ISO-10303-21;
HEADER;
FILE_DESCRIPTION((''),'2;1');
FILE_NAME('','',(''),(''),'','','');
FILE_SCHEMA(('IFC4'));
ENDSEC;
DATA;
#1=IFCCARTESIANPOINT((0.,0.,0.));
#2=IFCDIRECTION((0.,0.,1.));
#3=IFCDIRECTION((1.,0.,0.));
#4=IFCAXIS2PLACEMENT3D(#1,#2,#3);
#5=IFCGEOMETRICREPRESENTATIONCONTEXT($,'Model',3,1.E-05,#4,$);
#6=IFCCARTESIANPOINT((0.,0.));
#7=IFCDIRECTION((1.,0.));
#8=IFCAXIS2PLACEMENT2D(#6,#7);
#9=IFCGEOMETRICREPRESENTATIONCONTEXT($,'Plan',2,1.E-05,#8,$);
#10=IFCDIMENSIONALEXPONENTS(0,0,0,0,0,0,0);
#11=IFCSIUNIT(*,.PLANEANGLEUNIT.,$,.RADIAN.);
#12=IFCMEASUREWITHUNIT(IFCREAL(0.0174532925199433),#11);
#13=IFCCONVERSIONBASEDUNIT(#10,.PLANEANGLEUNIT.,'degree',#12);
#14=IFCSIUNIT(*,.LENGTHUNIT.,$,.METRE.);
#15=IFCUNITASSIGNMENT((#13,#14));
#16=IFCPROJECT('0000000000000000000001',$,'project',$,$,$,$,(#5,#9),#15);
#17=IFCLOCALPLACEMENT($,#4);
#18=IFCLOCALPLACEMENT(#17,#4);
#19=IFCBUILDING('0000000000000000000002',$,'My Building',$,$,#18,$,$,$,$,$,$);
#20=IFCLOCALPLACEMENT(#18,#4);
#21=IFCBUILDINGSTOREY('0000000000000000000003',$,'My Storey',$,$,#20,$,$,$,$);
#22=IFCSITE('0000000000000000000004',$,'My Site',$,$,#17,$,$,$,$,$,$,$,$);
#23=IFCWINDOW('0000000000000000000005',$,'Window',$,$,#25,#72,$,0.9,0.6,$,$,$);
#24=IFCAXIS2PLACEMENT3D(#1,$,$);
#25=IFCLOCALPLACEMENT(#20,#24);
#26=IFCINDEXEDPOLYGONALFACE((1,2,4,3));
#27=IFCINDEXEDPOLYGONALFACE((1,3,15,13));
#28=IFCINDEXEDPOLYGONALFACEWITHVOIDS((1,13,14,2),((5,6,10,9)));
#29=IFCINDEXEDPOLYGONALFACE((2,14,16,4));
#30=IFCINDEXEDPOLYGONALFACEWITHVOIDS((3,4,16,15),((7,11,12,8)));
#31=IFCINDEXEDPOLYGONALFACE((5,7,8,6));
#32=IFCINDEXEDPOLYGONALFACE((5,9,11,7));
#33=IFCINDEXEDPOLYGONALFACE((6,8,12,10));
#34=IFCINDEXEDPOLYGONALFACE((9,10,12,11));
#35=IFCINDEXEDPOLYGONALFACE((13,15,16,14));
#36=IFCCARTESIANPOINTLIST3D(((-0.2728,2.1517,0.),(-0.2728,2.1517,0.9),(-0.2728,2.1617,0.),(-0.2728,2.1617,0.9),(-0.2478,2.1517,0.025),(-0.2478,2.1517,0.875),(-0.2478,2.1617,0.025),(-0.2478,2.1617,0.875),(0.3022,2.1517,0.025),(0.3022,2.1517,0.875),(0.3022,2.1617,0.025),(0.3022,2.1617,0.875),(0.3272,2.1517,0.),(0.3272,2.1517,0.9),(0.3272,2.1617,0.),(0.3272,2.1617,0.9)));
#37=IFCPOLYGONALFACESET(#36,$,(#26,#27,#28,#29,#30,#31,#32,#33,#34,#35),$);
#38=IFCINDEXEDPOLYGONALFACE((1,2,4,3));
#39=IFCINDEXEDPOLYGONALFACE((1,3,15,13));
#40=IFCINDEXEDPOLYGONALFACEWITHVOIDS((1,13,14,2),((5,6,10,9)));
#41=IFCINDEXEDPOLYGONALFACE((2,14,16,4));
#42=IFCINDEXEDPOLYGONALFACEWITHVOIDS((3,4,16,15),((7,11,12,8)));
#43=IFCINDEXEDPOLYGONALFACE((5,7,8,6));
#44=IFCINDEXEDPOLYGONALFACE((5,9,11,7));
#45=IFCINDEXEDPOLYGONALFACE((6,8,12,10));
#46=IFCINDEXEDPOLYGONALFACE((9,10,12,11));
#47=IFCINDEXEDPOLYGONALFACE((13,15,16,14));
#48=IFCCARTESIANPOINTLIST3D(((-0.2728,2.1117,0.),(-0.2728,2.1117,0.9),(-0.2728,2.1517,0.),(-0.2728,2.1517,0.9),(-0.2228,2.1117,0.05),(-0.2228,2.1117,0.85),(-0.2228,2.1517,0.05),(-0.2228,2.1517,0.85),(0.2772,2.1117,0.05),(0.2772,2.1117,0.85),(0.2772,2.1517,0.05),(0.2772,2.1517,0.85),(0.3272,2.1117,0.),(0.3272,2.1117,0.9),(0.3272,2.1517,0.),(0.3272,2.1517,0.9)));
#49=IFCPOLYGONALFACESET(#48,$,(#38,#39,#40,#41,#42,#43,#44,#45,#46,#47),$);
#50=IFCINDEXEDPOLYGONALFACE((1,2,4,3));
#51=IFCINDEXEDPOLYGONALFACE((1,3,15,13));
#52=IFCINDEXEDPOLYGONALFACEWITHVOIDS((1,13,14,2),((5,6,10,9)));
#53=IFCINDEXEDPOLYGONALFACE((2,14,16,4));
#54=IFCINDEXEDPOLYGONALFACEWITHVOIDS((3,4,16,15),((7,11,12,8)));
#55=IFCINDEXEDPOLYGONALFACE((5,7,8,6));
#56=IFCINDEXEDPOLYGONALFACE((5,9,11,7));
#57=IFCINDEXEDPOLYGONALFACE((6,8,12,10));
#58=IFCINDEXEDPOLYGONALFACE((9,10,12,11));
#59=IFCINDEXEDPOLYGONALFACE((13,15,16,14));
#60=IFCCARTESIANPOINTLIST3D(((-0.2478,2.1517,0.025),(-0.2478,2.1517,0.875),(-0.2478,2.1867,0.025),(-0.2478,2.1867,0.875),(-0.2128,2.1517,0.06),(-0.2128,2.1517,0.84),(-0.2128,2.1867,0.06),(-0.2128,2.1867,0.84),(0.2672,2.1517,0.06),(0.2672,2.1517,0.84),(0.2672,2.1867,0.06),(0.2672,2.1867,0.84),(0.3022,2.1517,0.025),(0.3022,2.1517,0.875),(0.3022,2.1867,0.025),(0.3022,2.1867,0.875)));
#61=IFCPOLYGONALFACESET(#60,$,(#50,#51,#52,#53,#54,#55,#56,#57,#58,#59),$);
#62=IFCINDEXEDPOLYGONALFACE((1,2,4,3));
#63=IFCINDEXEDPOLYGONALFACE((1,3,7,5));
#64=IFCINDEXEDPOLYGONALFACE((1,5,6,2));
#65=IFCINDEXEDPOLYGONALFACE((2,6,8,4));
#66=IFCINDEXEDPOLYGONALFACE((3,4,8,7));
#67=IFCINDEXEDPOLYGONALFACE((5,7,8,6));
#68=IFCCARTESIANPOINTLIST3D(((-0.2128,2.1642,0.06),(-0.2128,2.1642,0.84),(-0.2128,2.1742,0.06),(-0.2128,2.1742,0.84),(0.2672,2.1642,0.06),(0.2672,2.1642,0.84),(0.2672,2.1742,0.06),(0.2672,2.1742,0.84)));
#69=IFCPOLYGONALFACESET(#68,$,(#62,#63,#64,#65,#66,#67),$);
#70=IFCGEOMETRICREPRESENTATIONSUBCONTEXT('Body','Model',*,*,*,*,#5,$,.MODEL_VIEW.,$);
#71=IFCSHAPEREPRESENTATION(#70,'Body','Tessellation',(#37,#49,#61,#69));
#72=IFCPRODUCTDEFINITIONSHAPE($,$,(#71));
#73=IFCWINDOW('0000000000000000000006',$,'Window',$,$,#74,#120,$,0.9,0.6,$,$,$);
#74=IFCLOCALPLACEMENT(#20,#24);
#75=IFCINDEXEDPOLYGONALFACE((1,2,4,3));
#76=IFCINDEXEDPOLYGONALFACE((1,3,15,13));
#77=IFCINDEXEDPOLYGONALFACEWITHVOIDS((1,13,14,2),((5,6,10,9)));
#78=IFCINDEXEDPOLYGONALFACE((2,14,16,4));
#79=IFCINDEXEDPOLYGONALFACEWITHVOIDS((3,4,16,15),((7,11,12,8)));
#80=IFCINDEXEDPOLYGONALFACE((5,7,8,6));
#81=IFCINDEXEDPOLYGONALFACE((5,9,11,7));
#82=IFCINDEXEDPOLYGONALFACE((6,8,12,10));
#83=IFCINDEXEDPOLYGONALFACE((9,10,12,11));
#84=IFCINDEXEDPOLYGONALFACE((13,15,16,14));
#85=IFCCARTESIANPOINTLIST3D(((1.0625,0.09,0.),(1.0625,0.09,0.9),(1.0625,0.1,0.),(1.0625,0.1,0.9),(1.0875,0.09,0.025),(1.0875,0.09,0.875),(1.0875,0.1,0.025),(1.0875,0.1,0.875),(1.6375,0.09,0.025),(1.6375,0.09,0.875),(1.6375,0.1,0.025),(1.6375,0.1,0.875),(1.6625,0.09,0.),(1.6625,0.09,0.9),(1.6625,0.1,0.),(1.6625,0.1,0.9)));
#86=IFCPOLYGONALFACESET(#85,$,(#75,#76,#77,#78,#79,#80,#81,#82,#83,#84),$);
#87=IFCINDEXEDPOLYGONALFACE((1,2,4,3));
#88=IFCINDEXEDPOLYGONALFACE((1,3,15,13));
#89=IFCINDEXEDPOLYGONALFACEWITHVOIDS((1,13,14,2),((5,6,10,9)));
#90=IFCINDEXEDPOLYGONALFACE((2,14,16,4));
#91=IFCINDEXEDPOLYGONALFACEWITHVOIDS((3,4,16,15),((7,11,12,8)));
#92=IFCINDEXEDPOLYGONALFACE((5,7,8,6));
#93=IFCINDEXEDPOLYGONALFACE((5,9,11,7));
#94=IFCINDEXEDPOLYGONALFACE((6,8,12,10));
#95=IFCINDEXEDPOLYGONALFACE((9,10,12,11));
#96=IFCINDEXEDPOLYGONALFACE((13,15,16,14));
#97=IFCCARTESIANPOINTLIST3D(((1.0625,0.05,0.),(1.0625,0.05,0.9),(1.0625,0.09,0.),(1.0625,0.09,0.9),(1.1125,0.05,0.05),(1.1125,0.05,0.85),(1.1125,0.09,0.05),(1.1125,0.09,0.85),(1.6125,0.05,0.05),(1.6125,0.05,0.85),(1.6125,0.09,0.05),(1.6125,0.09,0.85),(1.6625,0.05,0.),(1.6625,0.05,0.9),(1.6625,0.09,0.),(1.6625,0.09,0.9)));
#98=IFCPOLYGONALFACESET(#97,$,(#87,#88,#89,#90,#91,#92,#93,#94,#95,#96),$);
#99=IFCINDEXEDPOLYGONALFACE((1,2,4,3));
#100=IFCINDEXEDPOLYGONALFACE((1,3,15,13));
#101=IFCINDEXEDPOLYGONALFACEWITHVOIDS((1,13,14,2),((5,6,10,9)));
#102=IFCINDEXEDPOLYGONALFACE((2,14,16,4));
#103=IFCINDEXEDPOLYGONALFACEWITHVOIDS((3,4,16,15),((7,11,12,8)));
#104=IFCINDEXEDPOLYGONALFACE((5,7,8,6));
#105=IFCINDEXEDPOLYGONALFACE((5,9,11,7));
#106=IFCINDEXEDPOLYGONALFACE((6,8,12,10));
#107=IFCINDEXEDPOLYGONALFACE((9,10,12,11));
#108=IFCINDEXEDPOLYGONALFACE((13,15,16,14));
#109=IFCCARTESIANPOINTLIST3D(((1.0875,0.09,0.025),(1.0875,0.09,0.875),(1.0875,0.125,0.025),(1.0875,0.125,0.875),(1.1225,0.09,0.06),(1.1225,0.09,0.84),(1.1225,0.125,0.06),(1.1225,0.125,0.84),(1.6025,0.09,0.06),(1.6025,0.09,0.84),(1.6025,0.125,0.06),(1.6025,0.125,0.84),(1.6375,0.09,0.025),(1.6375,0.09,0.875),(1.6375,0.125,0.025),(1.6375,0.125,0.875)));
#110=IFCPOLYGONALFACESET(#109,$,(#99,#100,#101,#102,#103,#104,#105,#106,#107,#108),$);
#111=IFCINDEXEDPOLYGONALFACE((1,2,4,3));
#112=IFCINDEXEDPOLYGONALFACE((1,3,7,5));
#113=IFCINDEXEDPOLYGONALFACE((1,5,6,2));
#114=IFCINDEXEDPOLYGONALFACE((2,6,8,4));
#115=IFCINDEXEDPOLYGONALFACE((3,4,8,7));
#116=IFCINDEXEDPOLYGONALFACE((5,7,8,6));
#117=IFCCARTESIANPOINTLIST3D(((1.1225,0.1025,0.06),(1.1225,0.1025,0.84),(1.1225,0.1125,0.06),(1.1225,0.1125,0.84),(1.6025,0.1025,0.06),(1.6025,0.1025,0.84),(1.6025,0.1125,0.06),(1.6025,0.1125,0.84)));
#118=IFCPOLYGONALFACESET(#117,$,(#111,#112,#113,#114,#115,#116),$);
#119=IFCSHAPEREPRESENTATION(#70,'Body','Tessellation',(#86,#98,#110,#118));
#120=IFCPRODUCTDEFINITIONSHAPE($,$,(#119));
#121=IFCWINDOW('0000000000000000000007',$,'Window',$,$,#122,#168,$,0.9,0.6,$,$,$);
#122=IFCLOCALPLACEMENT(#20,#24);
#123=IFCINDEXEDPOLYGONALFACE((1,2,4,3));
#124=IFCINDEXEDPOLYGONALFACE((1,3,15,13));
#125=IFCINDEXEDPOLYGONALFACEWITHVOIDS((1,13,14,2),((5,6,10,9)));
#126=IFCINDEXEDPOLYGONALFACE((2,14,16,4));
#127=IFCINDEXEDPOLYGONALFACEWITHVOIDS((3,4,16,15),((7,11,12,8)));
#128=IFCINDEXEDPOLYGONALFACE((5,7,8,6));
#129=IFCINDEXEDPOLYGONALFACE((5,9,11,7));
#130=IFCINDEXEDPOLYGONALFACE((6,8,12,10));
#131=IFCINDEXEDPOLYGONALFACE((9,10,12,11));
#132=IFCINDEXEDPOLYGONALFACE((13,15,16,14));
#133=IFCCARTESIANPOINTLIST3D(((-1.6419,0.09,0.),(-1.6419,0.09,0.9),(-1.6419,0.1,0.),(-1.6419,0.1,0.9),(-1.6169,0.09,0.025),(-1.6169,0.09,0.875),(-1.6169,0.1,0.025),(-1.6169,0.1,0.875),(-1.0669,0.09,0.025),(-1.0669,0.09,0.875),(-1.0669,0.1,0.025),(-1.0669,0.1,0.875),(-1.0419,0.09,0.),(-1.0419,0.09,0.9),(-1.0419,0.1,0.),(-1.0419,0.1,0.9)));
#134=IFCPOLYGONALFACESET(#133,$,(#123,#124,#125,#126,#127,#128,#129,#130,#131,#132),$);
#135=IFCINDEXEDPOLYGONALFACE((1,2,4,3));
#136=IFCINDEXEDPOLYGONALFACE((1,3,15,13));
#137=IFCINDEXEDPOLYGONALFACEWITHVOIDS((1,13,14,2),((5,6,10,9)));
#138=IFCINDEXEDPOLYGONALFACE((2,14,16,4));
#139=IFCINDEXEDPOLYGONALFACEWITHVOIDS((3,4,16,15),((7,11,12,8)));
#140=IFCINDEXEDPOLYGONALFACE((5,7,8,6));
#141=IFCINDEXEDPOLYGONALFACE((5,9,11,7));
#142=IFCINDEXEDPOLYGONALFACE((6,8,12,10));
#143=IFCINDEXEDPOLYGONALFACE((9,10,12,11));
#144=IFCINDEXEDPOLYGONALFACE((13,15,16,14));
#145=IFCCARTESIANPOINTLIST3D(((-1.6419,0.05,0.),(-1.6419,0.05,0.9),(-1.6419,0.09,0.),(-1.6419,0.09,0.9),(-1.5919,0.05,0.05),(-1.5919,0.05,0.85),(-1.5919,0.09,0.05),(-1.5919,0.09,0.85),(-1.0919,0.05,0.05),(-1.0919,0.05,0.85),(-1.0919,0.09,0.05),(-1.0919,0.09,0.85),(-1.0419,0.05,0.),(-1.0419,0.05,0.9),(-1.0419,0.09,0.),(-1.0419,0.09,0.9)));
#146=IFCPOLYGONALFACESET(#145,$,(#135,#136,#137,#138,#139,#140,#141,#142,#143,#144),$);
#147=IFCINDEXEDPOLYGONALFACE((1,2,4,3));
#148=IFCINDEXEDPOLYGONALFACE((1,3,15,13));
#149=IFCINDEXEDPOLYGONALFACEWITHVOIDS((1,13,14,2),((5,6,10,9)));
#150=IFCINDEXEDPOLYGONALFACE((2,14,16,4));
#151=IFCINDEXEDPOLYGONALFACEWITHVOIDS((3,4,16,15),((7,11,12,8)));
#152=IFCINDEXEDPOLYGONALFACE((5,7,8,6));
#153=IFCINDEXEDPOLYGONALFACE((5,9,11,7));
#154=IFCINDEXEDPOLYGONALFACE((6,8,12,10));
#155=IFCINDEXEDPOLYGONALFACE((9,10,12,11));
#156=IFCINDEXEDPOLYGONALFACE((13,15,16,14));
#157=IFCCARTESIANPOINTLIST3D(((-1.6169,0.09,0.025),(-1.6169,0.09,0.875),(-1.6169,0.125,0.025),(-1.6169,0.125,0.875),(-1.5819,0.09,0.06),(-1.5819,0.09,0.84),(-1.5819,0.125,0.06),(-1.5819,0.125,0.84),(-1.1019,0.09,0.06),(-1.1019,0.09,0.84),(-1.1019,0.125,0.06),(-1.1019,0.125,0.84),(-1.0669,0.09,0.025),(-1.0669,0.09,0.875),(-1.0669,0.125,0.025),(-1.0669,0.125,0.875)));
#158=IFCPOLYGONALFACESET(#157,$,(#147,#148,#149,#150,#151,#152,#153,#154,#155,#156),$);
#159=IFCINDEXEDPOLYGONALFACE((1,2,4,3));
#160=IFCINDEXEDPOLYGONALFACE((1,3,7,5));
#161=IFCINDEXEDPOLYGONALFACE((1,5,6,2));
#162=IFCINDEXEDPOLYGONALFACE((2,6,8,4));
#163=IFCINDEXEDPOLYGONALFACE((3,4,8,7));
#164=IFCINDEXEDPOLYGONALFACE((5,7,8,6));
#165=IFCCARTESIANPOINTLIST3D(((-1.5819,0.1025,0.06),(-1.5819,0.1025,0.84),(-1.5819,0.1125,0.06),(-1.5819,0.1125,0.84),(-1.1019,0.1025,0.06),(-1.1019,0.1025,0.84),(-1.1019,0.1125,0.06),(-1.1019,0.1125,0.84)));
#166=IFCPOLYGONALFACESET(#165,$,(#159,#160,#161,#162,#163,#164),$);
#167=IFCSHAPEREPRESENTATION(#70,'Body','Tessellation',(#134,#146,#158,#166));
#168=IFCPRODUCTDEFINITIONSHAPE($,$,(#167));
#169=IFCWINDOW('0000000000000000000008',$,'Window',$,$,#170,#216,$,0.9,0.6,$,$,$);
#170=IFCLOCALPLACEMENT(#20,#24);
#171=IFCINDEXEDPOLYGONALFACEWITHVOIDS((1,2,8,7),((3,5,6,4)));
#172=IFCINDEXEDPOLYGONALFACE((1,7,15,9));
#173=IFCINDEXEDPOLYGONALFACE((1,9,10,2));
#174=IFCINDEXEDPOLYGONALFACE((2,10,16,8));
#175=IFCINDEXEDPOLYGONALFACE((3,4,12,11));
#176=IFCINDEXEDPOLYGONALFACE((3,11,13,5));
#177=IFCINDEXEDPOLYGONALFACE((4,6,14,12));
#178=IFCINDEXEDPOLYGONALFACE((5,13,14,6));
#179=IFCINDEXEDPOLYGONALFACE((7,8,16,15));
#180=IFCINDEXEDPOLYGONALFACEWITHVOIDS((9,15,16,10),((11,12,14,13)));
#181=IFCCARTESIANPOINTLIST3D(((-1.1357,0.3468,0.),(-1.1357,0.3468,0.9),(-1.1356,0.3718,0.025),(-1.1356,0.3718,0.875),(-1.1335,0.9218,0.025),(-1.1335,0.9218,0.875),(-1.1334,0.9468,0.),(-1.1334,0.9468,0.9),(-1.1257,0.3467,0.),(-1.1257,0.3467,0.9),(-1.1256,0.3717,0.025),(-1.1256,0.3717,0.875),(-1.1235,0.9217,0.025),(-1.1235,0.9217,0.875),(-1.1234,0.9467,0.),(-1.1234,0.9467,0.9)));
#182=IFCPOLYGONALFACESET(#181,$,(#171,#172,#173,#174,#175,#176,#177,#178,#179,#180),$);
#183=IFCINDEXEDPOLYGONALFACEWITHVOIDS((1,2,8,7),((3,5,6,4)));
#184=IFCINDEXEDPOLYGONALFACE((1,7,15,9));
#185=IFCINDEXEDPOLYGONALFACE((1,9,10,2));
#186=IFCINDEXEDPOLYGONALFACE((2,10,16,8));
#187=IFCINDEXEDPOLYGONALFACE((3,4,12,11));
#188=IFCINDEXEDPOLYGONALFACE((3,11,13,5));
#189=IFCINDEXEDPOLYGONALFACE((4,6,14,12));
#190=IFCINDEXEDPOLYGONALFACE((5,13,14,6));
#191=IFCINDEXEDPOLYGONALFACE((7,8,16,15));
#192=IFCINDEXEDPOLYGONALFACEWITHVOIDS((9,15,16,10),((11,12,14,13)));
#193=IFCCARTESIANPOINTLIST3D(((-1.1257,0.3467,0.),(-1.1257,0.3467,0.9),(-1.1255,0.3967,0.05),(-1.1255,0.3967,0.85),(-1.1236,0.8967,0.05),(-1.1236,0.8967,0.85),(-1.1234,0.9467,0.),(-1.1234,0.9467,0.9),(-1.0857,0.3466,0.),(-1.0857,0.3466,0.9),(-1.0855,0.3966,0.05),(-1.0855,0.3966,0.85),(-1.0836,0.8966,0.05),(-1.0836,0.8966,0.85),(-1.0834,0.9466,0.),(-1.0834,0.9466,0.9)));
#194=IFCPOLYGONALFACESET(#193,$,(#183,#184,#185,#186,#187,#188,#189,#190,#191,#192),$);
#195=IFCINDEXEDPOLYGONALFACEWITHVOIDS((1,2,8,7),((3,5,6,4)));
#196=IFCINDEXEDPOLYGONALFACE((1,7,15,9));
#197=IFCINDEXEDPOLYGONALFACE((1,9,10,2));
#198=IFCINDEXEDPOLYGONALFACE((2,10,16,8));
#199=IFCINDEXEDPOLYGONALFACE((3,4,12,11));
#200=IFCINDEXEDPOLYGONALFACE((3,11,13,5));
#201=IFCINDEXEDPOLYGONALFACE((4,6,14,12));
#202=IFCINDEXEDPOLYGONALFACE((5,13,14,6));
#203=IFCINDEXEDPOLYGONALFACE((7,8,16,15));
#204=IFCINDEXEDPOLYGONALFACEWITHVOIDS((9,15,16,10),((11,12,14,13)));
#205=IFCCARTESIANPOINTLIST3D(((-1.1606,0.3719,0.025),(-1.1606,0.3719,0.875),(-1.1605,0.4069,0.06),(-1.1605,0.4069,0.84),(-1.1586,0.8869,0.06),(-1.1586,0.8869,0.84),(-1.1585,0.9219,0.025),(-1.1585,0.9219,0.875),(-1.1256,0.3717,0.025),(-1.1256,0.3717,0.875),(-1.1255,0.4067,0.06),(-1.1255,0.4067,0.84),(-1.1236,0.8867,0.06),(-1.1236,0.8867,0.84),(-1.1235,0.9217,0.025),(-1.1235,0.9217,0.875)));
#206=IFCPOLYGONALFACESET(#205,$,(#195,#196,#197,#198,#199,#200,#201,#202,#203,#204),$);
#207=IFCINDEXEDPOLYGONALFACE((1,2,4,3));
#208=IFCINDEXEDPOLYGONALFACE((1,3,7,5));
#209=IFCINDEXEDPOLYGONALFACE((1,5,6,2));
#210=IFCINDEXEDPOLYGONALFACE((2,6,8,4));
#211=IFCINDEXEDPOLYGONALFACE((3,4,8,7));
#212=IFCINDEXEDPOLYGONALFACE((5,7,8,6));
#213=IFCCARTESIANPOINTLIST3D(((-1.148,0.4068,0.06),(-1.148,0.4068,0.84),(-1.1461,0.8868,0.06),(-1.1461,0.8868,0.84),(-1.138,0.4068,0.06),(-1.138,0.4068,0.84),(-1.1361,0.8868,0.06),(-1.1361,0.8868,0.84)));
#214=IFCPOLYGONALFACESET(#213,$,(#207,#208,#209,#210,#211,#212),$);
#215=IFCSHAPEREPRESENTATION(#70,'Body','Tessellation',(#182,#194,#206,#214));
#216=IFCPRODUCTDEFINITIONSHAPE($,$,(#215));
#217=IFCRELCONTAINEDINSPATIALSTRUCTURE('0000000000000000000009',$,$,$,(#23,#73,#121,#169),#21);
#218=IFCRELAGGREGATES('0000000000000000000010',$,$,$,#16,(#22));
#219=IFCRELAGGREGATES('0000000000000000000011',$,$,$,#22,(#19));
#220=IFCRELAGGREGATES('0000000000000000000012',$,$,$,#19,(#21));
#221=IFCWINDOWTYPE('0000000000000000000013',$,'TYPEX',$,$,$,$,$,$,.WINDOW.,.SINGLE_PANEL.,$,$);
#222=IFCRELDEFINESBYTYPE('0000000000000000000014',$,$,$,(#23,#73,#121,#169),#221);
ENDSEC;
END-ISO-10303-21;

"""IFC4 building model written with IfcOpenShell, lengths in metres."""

from ifc_helpers import new_model, entity, si_unit, converted_unit, frame, origin_with_axes, origin_2d_with_axis, place, context, subcontext, project, spatial, line, indexed_curve, outline, extrude, shape, source, transform, mapped, type_object, type_shapes, element, save


model = new_model("IFC4")

# Units and contexts
model_context = context("Model", 3, precision=1e-05, world=origin_with_axes())
plan_context = context("Plan", 2, precision=1e-05, world=origin_2d_with_axis())
body_context_1 = subcontext(model_context, "Body", "Model", "MODEL_VIEW")
body_context_2 = subcontext(plan_context, "Body", "Plan", "PLAN_VIEW")
ifc_project = project(units=[converted_unit("PLANEANGLEUNIT", "degree", entity("IfcReal", 0.0174532925199433), si_unit("PLANEANGLEUNIT", "RADIAN"), dimensions=[0, 0, 0, 0, 0, 0, 0]), si_unit("LENGTHUNIT", "METRE")], contexts=[model_context, plan_context])

# Site, building, storey
site_placement = place(None, origin_with_axes())
site = spatial("IfcSite", under=ifc_project, at=site_placement, Name="My Site")
building_placement = place(site_placement, origin_with_axes())
building = spatial("IfcBuilding", under=site, at=building_placement, Name="My Building")
storey_placement = place(building_placement, origin_with_axes())
storey = spatial("IfcBuildingStorey", under=building, at=storey_placement, Name="My Storey")

# Windows
window_type = type_object("IfcWindowType", Name="TYPEX", PartitioningType="SINGLE_PANEL", PredefinedType="WINDOW")
shared_shape_1 = source(origin_with_axes(), body_context_1, "Body", "SweptSolid", [
    extrude(outline(indexed_curve([(0.0, 0.0), (0.6, 0.0), (0.6, 0.9), (0.0, 0.9)], segments=[line(1, 2, 3, 4, 1)]), holes=[indexed_curve([(0.025, 0.025), (0.575, 0.025), (0.575, 0.875), (0.025, 0.875)], segments=[line(1, 2, 3, 4, 1)])]), frame((0.0, 0.09, 0.0), z_axis=(0.0, -1.0, 0.0), x_axis=(1.0, 0.0, 0.0)), (0.0, 0.0, -1.0), 0.01),
    extrude(outline(indexed_curve([(0.0, 0.0), (0.6, 0.0), (0.6, 0.9), (0.0, 0.9)], segments=[line(1, 2, 3, 4, 1)]), holes=[indexed_curve([(0.05, 0.05), (0.55, 0.05), (0.55, 0.85), (0.05, 0.85)], segments=[line(1, 2, 3, 4, 1)])]), frame((0.0, 0.05, 0.0), z_axis=(0.0, -1.0, 0.0), x_axis=(1.0, 0.0, 0.0)), (0.0, 0.0, -1.0), 0.04),
    extrude(outline(indexed_curve([(0.0, 0.0), (0.55, 0.0), (0.55, 0.85), (0.0, 0.85)], segments=[line(1, 2, 3, 4, 1)]), holes=[indexed_curve([(0.035, 0.035), (0.515, 0.035), (0.515, 0.815), (0.035, 0.815)], segments=[line(1, 2, 3, 4, 1)])]), frame((0.025, 0.09, 0.025), z_axis=(0.0, -1.0, 0.0), x_axis=(1.0, 0.0, 0.0)), (0.0, 0.0, -1.0), 0.035),
    extrude(outline(indexed_curve([(0.035, 0.035), (0.515, 0.035), (0.515, 0.815), (0.035, 0.815)], segments=[line(1, 2, 3, 4, 1)])), frame((0.025, 0.1025, 0.025), z_axis=(0.0, -1.0, 0.0), x_axis=(1.0, 0.0, 0.0)), (0.0, 0.0, -1.0), 0.01),
])
shared_shape_2 = source(origin_with_axes(), body_context_2, "Body", "Curve2D", [
    entity("IfcIndexedPolyCurve", entity("IfcCartesianPointList2D", [[0.05, 0.05], [0.55, 0.05]])),
    entity("IfcIndexedPolyCurve", entity("IfcCartesianPointList2D", [[0.0, 0.1], [0.025, 0.1], [0.025, 0.09], [0.05, 0.09], [0.05, 0.05], [0.0, 0.05]]), [entity("IfcLineIndex", [1, 2, 3, 4, 5, 6, 1])]),
    entity("IfcIndexedPolyCurve", entity("IfcCartesianPointList2D", [[0.6, 0.1], [0.575, 0.1], [0.575, 0.09], [0.55, 0.09], [0.55, 0.05], [0.6, 0.05]]), [entity("IfcLineIndex", [1, 2, 3, 4, 5, 6, 1])]),
    entity("IfcIndexedPolyCurve", entity("IfcCartesianPointList2D", [[0.025, 0.09], [0.06, 0.09], [0.06, 0.125], [0.025, 0.125]]), [entity("IfcLineIndex", [1, 2, 3, 4, 1])]),
    entity("IfcIndexedPolyCurve", entity("IfcCartesianPointList2D", [[0.575, 0.09], [0.54, 0.09], [0.54, 0.125], [0.575, 0.125]]), [entity("IfcLineIndex", [1, 2, 3, 4, 1])]),
    entity("IfcIndexedPolyCurve", entity("IfcCartesianPointList2D", [[0.06, 0.09], [0.54, 0.09]])),
    entity("IfcIndexedPolyCurve", entity("IfcCartesianPointList2D", [[0.06, 0.125], [0.54, 0.125]])),
    entity("IfcIndexedPolyCurve", entity("IfcCartesianPointList2D", [[0.06, 0.1075], [0.54, 0.1075]])),
])
type_shapes(window_type, [shared_shape_1, shared_shape_2])
for number, where, z_axis, x_axis, name in (
    (1, (-0.2728, 2.0617, 0.0), (0.0, 0.0, 1.0), (1.0, 0.0, 0.0), "Window"),
    (2, (1.0625, 0.0, 0.0), (0.0, 0.0, 1.0), (1.0, 0.0, 0.0), "Window"),
    (3, (-1.6419, 0.0, 0.0), (0.0, 0.0, 1.0), (1.0, 0.0, 0.0), "Window"),
    (4, (-1.0357, 0.3464, 0.0), (0.0, 0.0, 1.0), (0.003853, 0.999993, 0.0), "Window"),
):
    element("IfcWindow", number, at=place(storey_placement, frame(where, z_axis=z_axis, x_axis=x_axis)), inside=storey, type_object=window_type, Name=name, OverallHeight=0.9, OverallWidth=0.6, shapes=[
        shape(body_context_1, "Body", "MappedRepresentation", [mapped(shared_shape_1, transform((0.0, 0.0, 0.0), x_axis=(1.0, 0.0, 0.0), y_axis=(0.0, 1.0, 0.0), z_axis=(0.0, 0.0, 1.0), scale=1.0))]),
        shape(body_context_2, "Body", "MappedRepresentation", [mapped(shared_shape_2, transform((0.0, 0.0, 0.0), x_axis=(1.0, 0.0, 0.0), y_axis=(0.0, 1.0, 0.0), z_axis=(0.0, 0.0, 1.0), scale=1.0))]),
    ])

save(model, "model.ifc")
